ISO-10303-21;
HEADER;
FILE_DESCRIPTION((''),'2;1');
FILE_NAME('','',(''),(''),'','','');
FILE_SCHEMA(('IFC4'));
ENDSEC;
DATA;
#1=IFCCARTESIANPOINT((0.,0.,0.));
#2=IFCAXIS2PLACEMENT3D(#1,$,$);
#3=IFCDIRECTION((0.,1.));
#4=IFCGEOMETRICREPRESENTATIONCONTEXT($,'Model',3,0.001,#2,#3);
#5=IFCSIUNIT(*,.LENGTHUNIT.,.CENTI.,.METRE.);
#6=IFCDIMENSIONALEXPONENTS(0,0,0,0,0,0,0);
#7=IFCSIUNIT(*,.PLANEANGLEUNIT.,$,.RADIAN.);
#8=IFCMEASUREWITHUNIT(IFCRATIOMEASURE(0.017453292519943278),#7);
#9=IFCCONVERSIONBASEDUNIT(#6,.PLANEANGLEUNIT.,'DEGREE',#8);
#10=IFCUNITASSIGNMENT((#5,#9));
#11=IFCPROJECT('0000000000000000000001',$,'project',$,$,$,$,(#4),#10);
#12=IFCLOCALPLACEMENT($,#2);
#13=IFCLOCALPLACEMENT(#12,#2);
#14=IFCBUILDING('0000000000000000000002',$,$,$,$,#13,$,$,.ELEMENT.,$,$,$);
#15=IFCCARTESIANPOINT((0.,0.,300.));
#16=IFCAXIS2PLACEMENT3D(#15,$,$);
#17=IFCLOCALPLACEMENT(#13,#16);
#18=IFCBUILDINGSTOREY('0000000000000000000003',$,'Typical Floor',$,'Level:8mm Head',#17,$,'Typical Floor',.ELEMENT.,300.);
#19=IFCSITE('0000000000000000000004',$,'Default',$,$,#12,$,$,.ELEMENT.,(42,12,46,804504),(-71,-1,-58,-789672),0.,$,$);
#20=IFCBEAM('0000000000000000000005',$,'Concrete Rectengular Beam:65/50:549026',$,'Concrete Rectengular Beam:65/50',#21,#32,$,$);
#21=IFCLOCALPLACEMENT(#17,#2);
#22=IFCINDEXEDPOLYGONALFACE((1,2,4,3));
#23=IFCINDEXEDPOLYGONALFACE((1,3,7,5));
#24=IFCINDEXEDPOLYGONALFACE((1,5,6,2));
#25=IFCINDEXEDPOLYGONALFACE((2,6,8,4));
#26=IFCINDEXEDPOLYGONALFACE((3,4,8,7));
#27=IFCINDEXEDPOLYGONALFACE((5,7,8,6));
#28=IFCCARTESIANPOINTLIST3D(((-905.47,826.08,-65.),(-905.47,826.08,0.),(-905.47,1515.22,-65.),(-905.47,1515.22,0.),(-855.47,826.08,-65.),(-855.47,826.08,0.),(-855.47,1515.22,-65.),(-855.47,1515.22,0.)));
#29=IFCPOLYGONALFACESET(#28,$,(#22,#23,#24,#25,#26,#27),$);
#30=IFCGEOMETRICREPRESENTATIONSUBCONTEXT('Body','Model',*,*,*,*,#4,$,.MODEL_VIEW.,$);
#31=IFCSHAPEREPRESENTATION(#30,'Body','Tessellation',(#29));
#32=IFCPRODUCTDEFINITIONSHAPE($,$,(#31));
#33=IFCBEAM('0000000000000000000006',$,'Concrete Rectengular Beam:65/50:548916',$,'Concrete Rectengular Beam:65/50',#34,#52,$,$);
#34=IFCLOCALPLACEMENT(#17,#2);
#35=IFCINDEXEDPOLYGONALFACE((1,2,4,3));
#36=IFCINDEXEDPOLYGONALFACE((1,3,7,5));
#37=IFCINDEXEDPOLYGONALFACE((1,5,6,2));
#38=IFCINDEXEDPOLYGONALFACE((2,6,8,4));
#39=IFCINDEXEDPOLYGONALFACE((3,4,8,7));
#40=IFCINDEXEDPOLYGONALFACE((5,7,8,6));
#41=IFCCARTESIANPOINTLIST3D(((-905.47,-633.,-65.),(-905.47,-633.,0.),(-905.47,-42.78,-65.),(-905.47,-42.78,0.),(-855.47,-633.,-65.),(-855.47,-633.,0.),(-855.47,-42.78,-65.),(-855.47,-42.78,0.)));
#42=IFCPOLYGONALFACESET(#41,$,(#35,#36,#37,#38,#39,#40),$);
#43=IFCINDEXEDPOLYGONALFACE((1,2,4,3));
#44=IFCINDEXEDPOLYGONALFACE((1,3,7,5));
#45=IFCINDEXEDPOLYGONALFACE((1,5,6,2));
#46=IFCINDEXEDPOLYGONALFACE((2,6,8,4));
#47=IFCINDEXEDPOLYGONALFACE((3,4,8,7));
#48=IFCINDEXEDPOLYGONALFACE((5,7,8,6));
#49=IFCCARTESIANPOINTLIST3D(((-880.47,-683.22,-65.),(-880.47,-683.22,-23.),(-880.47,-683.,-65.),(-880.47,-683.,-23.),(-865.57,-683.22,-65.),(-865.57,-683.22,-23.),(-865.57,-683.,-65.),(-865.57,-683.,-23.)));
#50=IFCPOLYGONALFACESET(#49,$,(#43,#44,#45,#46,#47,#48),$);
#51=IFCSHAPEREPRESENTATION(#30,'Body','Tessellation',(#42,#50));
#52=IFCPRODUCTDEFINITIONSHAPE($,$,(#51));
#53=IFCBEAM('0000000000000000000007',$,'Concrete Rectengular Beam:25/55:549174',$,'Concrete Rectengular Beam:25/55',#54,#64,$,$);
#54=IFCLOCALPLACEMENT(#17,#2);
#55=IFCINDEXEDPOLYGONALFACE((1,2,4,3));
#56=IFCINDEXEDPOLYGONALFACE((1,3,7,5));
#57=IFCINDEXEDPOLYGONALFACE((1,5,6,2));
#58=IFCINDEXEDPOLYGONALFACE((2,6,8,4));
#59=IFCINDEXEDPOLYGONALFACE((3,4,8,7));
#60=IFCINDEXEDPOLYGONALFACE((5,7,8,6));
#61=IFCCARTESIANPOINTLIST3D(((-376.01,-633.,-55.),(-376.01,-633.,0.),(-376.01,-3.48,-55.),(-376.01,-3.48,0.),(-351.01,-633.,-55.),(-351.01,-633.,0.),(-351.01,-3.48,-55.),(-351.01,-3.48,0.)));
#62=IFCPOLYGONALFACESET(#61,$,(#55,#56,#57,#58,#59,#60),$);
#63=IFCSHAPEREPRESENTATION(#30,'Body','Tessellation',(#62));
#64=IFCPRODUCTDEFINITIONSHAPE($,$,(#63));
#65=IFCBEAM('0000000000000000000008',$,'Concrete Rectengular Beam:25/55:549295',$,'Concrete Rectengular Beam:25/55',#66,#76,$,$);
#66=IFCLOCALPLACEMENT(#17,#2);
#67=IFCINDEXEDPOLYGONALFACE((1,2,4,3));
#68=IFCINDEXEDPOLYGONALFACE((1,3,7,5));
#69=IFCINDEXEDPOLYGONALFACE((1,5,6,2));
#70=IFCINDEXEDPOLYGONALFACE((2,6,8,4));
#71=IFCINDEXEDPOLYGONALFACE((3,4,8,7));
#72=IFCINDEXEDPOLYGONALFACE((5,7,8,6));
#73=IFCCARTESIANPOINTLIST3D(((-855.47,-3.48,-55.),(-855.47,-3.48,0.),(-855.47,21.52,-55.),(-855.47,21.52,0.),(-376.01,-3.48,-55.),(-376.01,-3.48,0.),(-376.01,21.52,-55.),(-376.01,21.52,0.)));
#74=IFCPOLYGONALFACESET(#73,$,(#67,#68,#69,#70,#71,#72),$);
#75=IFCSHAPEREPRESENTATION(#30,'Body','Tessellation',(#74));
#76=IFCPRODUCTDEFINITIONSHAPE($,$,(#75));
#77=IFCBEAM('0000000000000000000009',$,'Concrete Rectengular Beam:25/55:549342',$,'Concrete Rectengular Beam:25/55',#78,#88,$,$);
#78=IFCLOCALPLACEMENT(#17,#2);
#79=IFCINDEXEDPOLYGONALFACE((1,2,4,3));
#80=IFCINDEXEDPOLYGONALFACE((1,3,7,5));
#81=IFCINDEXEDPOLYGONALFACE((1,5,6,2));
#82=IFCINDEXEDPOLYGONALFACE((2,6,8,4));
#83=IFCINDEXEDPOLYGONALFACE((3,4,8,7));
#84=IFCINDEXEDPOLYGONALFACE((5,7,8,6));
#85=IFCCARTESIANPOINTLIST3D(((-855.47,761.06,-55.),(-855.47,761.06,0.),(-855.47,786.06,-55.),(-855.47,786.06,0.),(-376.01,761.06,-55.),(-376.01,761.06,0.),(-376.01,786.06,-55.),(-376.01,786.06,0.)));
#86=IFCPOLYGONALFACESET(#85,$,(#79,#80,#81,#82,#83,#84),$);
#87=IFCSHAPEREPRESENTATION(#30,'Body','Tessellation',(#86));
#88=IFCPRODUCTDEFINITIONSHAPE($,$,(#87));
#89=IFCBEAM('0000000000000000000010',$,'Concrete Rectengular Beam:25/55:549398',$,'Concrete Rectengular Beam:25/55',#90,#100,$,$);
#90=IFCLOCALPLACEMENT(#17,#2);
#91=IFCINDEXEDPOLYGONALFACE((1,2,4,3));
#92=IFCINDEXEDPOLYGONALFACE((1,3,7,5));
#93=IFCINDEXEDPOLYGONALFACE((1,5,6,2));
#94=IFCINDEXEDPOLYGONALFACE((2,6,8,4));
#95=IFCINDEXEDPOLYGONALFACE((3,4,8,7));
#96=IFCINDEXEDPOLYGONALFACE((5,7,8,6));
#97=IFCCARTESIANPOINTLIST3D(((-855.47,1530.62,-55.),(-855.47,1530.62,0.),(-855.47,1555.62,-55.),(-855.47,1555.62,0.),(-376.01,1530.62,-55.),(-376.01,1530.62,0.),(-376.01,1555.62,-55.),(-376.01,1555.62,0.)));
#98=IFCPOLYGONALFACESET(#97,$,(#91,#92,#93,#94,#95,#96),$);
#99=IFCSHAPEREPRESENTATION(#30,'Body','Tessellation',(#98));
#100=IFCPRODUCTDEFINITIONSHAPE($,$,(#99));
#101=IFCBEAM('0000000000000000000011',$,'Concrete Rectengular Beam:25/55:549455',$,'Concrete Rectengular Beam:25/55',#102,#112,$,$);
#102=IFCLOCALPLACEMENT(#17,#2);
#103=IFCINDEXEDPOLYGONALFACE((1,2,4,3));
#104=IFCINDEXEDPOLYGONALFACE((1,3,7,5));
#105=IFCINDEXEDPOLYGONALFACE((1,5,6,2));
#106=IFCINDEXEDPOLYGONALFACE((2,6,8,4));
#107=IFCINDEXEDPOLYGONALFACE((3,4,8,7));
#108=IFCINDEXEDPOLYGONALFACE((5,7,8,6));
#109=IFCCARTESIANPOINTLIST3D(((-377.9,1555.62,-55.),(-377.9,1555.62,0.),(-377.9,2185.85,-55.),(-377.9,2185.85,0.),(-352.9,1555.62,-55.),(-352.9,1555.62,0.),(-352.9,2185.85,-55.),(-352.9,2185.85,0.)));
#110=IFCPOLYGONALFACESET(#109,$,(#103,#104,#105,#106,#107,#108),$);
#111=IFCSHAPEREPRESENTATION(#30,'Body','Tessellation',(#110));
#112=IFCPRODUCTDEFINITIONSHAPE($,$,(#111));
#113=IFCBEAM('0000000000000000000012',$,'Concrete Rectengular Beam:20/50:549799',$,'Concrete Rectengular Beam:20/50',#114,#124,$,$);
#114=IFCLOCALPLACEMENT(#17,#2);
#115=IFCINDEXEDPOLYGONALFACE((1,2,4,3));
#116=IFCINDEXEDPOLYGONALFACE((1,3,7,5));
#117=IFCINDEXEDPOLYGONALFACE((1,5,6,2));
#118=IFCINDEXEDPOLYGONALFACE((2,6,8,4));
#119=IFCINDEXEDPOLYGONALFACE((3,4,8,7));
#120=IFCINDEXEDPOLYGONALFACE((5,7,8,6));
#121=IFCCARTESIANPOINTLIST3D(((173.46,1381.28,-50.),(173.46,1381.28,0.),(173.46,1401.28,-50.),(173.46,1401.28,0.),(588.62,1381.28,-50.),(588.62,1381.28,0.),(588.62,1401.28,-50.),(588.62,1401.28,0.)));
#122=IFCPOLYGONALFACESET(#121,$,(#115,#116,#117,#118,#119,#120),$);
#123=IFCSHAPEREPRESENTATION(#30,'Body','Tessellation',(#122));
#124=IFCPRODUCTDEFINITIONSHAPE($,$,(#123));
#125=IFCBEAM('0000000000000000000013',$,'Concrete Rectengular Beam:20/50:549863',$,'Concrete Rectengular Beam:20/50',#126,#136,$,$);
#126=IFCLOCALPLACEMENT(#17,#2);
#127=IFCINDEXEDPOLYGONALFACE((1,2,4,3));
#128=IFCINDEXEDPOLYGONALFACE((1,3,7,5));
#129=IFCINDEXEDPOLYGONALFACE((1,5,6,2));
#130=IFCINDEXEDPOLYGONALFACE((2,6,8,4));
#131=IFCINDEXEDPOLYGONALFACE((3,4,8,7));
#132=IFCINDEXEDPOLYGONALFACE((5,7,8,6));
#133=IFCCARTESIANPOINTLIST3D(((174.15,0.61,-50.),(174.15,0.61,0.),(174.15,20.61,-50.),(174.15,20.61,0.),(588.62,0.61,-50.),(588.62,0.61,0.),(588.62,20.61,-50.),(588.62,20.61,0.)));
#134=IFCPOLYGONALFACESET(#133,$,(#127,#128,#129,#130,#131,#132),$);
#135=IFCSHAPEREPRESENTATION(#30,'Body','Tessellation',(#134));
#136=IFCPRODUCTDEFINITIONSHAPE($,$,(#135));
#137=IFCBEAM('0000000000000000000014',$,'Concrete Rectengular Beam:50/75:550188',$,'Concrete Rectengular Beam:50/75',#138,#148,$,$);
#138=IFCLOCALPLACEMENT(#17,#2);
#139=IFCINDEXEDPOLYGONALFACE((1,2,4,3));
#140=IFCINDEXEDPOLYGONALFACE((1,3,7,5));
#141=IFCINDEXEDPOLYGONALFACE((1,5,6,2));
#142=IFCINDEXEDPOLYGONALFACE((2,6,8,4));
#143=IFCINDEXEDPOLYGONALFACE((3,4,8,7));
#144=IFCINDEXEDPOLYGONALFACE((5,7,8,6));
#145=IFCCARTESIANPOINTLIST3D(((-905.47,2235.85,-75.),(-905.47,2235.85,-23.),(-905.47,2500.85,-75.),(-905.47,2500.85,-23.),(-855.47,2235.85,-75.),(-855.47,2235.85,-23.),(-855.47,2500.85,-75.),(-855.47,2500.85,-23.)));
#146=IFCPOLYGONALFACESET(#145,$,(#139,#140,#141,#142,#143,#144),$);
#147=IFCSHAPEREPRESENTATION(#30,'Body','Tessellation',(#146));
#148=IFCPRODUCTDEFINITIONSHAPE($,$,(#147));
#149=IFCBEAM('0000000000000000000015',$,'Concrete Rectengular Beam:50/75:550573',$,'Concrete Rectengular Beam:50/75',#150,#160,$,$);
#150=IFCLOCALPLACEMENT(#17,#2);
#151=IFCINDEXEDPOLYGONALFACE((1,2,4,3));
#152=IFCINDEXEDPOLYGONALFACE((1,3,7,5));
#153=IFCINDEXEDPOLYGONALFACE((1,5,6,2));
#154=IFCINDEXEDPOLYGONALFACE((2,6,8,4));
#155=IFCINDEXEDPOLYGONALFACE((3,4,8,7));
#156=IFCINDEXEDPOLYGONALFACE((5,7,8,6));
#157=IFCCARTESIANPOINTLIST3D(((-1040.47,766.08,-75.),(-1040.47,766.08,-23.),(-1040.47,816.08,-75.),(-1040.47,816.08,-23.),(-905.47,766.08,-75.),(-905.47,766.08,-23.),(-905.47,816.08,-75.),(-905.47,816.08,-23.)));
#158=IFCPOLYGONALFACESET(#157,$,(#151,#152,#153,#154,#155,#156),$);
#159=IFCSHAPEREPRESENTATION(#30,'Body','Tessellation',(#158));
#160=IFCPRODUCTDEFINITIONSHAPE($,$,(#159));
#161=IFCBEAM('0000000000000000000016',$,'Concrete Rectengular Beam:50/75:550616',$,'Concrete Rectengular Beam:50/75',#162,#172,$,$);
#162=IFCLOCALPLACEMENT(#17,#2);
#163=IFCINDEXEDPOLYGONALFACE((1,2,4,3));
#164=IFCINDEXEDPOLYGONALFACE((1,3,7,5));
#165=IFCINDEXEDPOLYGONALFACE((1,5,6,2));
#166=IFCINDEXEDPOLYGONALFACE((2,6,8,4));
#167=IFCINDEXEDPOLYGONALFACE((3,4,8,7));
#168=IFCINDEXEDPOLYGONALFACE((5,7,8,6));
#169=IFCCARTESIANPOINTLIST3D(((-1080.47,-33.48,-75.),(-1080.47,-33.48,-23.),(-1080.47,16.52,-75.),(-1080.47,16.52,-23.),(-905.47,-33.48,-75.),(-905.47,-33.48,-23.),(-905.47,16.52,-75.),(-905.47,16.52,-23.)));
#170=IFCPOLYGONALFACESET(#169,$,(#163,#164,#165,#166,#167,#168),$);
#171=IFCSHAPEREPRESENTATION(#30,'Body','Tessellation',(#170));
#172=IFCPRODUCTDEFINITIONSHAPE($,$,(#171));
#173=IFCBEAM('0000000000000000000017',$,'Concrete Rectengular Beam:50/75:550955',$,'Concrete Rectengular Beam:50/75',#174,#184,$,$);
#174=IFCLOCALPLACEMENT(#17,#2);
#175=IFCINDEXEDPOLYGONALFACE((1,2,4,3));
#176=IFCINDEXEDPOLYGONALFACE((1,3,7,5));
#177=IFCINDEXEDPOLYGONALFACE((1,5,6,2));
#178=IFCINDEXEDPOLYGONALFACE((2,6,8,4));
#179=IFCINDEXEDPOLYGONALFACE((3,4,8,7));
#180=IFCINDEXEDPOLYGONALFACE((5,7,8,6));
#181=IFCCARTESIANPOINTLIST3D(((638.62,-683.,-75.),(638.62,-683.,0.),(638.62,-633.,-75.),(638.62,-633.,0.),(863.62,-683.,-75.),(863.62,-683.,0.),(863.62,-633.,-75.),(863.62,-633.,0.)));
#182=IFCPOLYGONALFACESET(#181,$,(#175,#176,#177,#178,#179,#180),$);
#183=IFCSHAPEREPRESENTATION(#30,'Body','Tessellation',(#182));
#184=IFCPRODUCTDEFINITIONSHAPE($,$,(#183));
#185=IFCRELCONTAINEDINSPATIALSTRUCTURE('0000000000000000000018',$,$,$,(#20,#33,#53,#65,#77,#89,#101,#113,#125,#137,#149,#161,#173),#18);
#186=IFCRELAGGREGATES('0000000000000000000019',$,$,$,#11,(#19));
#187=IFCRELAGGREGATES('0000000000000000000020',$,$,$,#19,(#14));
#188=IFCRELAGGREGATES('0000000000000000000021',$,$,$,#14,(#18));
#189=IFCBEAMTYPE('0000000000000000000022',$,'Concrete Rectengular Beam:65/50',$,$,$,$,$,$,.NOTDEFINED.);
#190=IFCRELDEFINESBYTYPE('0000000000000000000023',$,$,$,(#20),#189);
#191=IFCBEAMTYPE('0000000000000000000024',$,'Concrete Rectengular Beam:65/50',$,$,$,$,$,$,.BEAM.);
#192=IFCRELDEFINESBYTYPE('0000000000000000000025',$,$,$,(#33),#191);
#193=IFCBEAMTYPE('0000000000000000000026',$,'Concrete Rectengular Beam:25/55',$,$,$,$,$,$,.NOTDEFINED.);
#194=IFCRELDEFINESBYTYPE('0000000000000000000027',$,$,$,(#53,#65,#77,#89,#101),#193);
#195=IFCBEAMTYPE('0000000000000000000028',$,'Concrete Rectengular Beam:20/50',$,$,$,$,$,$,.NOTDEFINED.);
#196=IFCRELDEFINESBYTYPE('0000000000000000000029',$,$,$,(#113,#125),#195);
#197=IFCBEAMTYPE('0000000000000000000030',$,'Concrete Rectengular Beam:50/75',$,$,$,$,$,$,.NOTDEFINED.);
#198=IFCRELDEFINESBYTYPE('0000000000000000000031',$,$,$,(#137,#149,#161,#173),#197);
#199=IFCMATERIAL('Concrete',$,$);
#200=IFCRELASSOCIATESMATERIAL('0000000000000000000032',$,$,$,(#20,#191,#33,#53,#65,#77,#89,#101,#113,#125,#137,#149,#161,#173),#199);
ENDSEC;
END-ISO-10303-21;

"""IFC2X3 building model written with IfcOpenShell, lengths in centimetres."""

from ifc_helpers import new_model, entity, si_unit, converted_unit, direction, frame, frame_2d, origin, place, context, subcontext, project, spatial, rectangle, extrude, source, transform, mapped, material, type_object, type_shapes, element, save


model = new_model("IFC2X3")

# Units and contexts
model_context = context("Model", 3, precision=0.001, world=origin(), true_north=direction((0.0, 1.0)))
body_context = subcontext(model_context, "Body", "Model", "MODEL_VIEW")
ifc_project = project(units=[si_unit("LENGTHUNIT", "METRE", prefix="CENTI"), converted_unit("PLANEANGLEUNIT", "DEGREE", entity("IfcRatioMeasure", 0.017453292519943278), si_unit("PLANEANGLEUNIT", "RADIAN"), dimensions=[0, 0, 0, 0, 0, 0, 0])], contexts=[model_context])

# Site, building, storey
site_placement = place(None, origin())
site = spatial("IfcSite", under=ifc_project, at=site_placement, Name="Default", CompositionType="ELEMENT", RefLatitude=(42, 12, 46, 804504), RefLongitude=(-71, -1, -58, -789672), RefElevation=0.0)
building_placement = place(site_placement, origin())
building = spatial("IfcBuilding", under=site, at=building_placement, CompositionType="ELEMENT")
storey_placement = place(building_placement, frame((0.0, 0.0, 300.0)))
storey = spatial("IfcBuildingStorey", under=building, at=storey_placement, Name="Typical Floor", ObjectType="Level:8mm Head", LongName="Typical Floor", CompositionType="ELEMENT", Elevation=300.0)

# Beams
ifc_material = material(Name="Concrete")
beam_type_1 = type_object("IfcBeamType", Name="Concrete Rectengular Beam:65/50", PredefinedType="NOTDEFINED")
beam_1_placement = place(storey_placement, frame((-880.47, 776.08, 0.0), z_axis=(0.0, 0.0, 1.0), x_axis=(0.0, 1.0, 0.0)))
element("IfcBeam", 1, at=beam_1_placement, inside=storey, type_object=beam_type_1, material=ifc_material, Name="Concrete Rectengular Beam:65/50:549026", ObjectType="Concrete Rectengular Beam:65/50", context=body_context, shape_type="SweptSolid", body=[
    extrude(rectangle(XDim=65.0, YDim=50.0, at=frame_2d((0.0, 0.0), x_axis=(1.0, 0.0))), frame((50.0, 0.0, -32.5), z_axis=(1.0, 0.0, 0.0), x_axis=(0.0, 0.0, -1.0)), (0.0, 0.0, 1.0), 689.13),
])
beam_type_2 = type_object("IfcBeamType", Name="Concrete Rectengular Beam:65/50", PredefinedType="BEAM", material=ifc_material)
shared_shape = source(origin(), body_context, "Body", "SweptSolid", [
    extrude(rectangle(XDim=65.0, YDim=50.0, at=frame_2d((0.0, 0.0), x_axis=(0.0, 1.0))), frame((-880.47, -42.78, 267.5), z_axis=(0.0, -1.0, 0.0), x_axis=(-1.0, 0.0, 0.0)), (0.0, 0.0, 1.0), 590.22),
    extrude(rectangle(XDim=42.0, YDim=14.9, at=frame_2d((0.0, 0.0), x_axis=(0.0, 1.0))), frame((-873.02, -683.0, 256.0), z_axis=(0.0, -1.0, 0.0), x_axis=(-1.0, 0.0, 0.0)), (0.0, 0.0, 1.0), 0.22),
])
type_shapes(beam_type_2, [shared_shape])
beam_2_placement = place(storey_placement, frame((0.0, 0.0, -300.0)))
element("IfcBeam", 2, at=beam_2_placement, inside=storey, type_object=beam_type_2, material=ifc_material, Name="Concrete Rectengular Beam:65/50:548916", ObjectType="Concrete Rectengular Beam:65/50", context=body_context, shape_type="MappedRepresentation", body=[
    mapped(shared_shape, transform((0.0, 0.0, 0.0), scale=1.0)),
])
beam_type_3 = type_object("IfcBeamType", Name="Concrete Rectengular Beam:25/55", PredefinedType="NOTDEFINED")
beam_3_placement = place(storey_placement, frame((-363.51, 9.02, 0.0), z_axis=(0.0, 0.0, 1.0), x_axis=(0.0, -1.0, 0.0)))
element("IfcBeam", 3, at=beam_3_placement, inside=storey, type_object=beam_type_3, material=ifc_material, Name="Concrete Rectengular Beam:25/55:549174", ObjectType="Concrete Rectengular Beam:25/55", context=body_context, shape_type="SweptSolid", body=[
    extrude(rectangle(XDim=55.0, YDim=25.0, at=frame_2d((0.0, 0.0), x_axis=(1.0, 0.0))), frame((12.5, 0.0, -27.5), z_axis=(1.0, 0.0, 0.0), x_axis=(0.0, 0.0, -1.0)), (0.0, 0.0, 1.0), 629.52),
])
beam_4_placement = place(storey_placement, frame((-363.51, 9.02, 0.0), z_axis=(0.0, 0.0, 1.0), x_axis=(-1.0, 0.0, 0.0)))
element("IfcBeam", 4, at=beam_4_placement, inside=storey, type_object=beam_type_3, material=ifc_material, Name="Concrete Rectengular Beam:25/55:549295", ObjectType="Concrete Rectengular Beam:25/55", context=body_context, shape_type="SweptSolid", body=[
    extrude(rectangle(XDim=55.0, YDim=25.0, at=frame_2d((0.0, 0.0), x_axis=(1.0, 0.0))), frame((12.5, 0.0, -27.5), z_axis=(1.0, 0.0, 0.0), x_axis=(0.0, 0.0, -1.0)), (0.0, 0.0, 1.0), 479.47),
])
beam_5_placement = place(storey_placement, frame((-880.47, 773.56, 0.0)))
element("IfcBeam", 5, at=beam_5_placement, inside=storey, type_object=beam_type_3, material=ifc_material, Name="Concrete Rectengular Beam:25/55:549342", ObjectType="Concrete Rectengular Beam:25/55", context=body_context, shape_type="SweptSolid", body=[
    extrude(rectangle(XDim=55.0, YDim=25.0, at=frame_2d((0.0, 0.0), x_axis=(1.0, 0.0))), frame((25.0, 0.0, -27.5), z_axis=(1.0, 0.0, 0.0), x_axis=(0.0, 0.0, -1.0)), (0.0, 0.0, 1.0), 479.47),
])
beam_6_placement = place(storey_placement, frame((-363.51, 1543.12, 0.0), z_axis=(0.0, 0.0, 1.0), x_axis=(-1.0, 0.0, 0.0)))
element("IfcBeam", 6, at=beam_6_placement, inside=storey, type_object=beam_type_3, material=ifc_material, Name="Concrete Rectengular Beam:25/55:549398", ObjectType="Concrete Rectengular Beam:25/55", context=body_context, shape_type="SweptSolid", body=[
    extrude(rectangle(XDim=55.0, YDim=25.0, at=frame_2d((0.0, 0.0), x_axis=(1.0, 0.0))), frame((12.5, 0.0, -27.5), z_axis=(1.0, 0.0, 0.0), x_axis=(0.0, 0.0, -1.0)), (0.0, 0.0, 1.0), 479.47),
])
beam_7_placement = place(storey_placement, frame((-365.4, 1543.12, 0.0), z_axis=(0.0, 0.0, 1.0), x_axis=(0.0, 1.0, 0.0)))
element("IfcBeam", 7, at=beam_7_placement, inside=storey, type_object=beam_type_3, material=ifc_material, Name="Concrete Rectengular Beam:25/55:549455", ObjectType="Concrete Rectengular Beam:25/55", context=body_context, shape_type="SweptSolid", body=[
    extrude(rectangle(XDim=55.0, YDim=25.0, at=frame_2d((0.0, 0.0), x_axis=(1.0, 0.0))), frame((12.5, 0.0, -27.5), z_axis=(1.0, 0.0, 0.0), x_axis=(0.0, 0.0, -1.0)), (0.0, 0.0, 1.0), 630.23),
])
beam_type_4 = type_object("IfcBeamType", Name="Concrete Rectengular Beam:20/50", PredefinedType="NOTDEFINED")
beam_8_placement = place(storey_placement, frame((163.46, 1391.28, 0.0)))
element("IfcBeam", 8, at=beam_8_placement, inside=storey, type_object=beam_type_4, material=ifc_material, Name="Concrete Rectengular Beam:20/50:549799", ObjectType="Concrete Rectengular Beam:20/50", context=body_context, shape_type="SweptSolid", body=[
    extrude(rectangle(XDim=50.0, YDim=20.0, at=frame_2d((0.0, 0.0), x_axis=(1.0, 0.0))), frame((10.0, 0.0, -25.0), z_axis=(1.0, 0.0, 0.0), x_axis=(0.0, 0.0, -1.0)), (0.0, 0.0, 1.0), 415.16),
])
beam_9_placement = place(storey_placement, frame((164.15, 10.61, 0.0)))
element("IfcBeam", 9, at=beam_9_placement, inside=storey, type_object=beam_type_4, material=ifc_material, Name="Concrete Rectengular Beam:20/50:549863", ObjectType="Concrete Rectengular Beam:20/50", context=body_context, shape_type="SweptSolid", body=[
    extrude(rectangle(XDim=50.0, YDim=20.0, at=frame_2d((0.0, 0.0), x_axis=(1.0, 0.0))), frame((10.0, 0.0, -25.0), z_axis=(1.0, 0.0, 0.0), x_axis=(0.0, 0.0, -1.0)), (0.0, 0.0, 1.0), 414.48),
])
beam_type_5 = type_object("IfcBeamType", Name="Concrete Rectengular Beam:50/75", PredefinedType="NOTDEFINED")
beam_10_placement = place(storey_placement, frame((-880.47, 2210.85, 0.0), z_axis=(0.0, 0.0, 1.0), x_axis=(0.0, 1.0, 0.0)))
element("IfcBeam", 10, at=beam_10_placement, inside=storey, type_object=beam_type_5, material=ifc_material, Name="Concrete Rectengular Beam:50/75:550188", ObjectType="Concrete Rectengular Beam:50/75", context=body_context, shape_type="SweptSolid", body=[
    extrude(rectangle(XDim=52.0, YDim=50.0, at=frame_2d((0.0, 0.0), x_axis=(1.0, 0.0))), frame((25.0, 0.0, -49.0), z_axis=(1.0, 0.0, 0.0), x_axis=(0.0, 0.0, -1.0)), (0.0, 0.0, 1.0), 265.0),
])
beam_11_placement = place(storey_placement, frame((-880.47, 816.08, 0.0), z_axis=(0.0, 0.0, 1.0), x_axis=(-1.0, 0.0, 0.0)))
element("IfcBeam", 11, at=beam_11_placement, inside=storey, type_object=beam_type_5, material=ifc_material, Name="Concrete Rectengular Beam:50/75:550573", ObjectType="Concrete Rectengular Beam:50/75", context=body_context, shape_type="SweptSolid", body=[
    extrude(rectangle(XDim=52.0, YDim=50.0, at=frame_2d((0.0, 0.0), x_axis=(1.0, 0.0))), frame((25.0, 25.0, -49.0), z_axis=(1.0, 0.0, 0.0), x_axis=(0.0, 0.0, -1.0)), (0.0, 0.0, 1.0), 135.0),
])
beam_12_placement = place(storey_placement, frame((-880.47, 16.52, 0.0), z_axis=(0.0, 0.0, 1.0), x_axis=(-1.0, 0.0, 0.0)))
element("IfcBeam", 12, at=beam_12_placement, inside=storey, type_object=beam_type_5, material=ifc_material, Name="Concrete Rectengular Beam:50/75:550616", ObjectType="Concrete Rectengular Beam:50/75", context=body_context, shape_type="SweptSolid", body=[
    extrude(rectangle(XDim=52.0, YDim=50.0, at=frame_2d((0.0, 0.0), x_axis=(1.0, 0.0))), frame((25.0, 25.0, -49.0), z_axis=(1.0, 0.0, 0.0), x_axis=(0.0, 0.0, -1.0)), (0.0, 0.0, 1.0), 175.0),
])
beam_13_placement = place(storey_placement, frame((613.62, -658.0, 0.0)))
element("IfcBeam", 13, at=beam_13_placement, inside=storey, type_object=beam_type_5, material=ifc_material, Name="Concrete Rectengular Beam:50/75:550955", ObjectType="Concrete Rectengular Beam:50/75", context=body_context, shape_type="SweptSolid", body=[
    extrude(rectangle(XDim=75.0, YDim=50.0, at=frame_2d((0.0, 0.0), x_axis=(1.0, 0.0))), frame((25.0, 0.0, -37.5), z_axis=(1.0, 0.0, 0.0), x_axis=(0.0, 0.0, -1.0)), (0.0, 0.0, 1.0), 225.0),
])

save(model, "model.ifc")
